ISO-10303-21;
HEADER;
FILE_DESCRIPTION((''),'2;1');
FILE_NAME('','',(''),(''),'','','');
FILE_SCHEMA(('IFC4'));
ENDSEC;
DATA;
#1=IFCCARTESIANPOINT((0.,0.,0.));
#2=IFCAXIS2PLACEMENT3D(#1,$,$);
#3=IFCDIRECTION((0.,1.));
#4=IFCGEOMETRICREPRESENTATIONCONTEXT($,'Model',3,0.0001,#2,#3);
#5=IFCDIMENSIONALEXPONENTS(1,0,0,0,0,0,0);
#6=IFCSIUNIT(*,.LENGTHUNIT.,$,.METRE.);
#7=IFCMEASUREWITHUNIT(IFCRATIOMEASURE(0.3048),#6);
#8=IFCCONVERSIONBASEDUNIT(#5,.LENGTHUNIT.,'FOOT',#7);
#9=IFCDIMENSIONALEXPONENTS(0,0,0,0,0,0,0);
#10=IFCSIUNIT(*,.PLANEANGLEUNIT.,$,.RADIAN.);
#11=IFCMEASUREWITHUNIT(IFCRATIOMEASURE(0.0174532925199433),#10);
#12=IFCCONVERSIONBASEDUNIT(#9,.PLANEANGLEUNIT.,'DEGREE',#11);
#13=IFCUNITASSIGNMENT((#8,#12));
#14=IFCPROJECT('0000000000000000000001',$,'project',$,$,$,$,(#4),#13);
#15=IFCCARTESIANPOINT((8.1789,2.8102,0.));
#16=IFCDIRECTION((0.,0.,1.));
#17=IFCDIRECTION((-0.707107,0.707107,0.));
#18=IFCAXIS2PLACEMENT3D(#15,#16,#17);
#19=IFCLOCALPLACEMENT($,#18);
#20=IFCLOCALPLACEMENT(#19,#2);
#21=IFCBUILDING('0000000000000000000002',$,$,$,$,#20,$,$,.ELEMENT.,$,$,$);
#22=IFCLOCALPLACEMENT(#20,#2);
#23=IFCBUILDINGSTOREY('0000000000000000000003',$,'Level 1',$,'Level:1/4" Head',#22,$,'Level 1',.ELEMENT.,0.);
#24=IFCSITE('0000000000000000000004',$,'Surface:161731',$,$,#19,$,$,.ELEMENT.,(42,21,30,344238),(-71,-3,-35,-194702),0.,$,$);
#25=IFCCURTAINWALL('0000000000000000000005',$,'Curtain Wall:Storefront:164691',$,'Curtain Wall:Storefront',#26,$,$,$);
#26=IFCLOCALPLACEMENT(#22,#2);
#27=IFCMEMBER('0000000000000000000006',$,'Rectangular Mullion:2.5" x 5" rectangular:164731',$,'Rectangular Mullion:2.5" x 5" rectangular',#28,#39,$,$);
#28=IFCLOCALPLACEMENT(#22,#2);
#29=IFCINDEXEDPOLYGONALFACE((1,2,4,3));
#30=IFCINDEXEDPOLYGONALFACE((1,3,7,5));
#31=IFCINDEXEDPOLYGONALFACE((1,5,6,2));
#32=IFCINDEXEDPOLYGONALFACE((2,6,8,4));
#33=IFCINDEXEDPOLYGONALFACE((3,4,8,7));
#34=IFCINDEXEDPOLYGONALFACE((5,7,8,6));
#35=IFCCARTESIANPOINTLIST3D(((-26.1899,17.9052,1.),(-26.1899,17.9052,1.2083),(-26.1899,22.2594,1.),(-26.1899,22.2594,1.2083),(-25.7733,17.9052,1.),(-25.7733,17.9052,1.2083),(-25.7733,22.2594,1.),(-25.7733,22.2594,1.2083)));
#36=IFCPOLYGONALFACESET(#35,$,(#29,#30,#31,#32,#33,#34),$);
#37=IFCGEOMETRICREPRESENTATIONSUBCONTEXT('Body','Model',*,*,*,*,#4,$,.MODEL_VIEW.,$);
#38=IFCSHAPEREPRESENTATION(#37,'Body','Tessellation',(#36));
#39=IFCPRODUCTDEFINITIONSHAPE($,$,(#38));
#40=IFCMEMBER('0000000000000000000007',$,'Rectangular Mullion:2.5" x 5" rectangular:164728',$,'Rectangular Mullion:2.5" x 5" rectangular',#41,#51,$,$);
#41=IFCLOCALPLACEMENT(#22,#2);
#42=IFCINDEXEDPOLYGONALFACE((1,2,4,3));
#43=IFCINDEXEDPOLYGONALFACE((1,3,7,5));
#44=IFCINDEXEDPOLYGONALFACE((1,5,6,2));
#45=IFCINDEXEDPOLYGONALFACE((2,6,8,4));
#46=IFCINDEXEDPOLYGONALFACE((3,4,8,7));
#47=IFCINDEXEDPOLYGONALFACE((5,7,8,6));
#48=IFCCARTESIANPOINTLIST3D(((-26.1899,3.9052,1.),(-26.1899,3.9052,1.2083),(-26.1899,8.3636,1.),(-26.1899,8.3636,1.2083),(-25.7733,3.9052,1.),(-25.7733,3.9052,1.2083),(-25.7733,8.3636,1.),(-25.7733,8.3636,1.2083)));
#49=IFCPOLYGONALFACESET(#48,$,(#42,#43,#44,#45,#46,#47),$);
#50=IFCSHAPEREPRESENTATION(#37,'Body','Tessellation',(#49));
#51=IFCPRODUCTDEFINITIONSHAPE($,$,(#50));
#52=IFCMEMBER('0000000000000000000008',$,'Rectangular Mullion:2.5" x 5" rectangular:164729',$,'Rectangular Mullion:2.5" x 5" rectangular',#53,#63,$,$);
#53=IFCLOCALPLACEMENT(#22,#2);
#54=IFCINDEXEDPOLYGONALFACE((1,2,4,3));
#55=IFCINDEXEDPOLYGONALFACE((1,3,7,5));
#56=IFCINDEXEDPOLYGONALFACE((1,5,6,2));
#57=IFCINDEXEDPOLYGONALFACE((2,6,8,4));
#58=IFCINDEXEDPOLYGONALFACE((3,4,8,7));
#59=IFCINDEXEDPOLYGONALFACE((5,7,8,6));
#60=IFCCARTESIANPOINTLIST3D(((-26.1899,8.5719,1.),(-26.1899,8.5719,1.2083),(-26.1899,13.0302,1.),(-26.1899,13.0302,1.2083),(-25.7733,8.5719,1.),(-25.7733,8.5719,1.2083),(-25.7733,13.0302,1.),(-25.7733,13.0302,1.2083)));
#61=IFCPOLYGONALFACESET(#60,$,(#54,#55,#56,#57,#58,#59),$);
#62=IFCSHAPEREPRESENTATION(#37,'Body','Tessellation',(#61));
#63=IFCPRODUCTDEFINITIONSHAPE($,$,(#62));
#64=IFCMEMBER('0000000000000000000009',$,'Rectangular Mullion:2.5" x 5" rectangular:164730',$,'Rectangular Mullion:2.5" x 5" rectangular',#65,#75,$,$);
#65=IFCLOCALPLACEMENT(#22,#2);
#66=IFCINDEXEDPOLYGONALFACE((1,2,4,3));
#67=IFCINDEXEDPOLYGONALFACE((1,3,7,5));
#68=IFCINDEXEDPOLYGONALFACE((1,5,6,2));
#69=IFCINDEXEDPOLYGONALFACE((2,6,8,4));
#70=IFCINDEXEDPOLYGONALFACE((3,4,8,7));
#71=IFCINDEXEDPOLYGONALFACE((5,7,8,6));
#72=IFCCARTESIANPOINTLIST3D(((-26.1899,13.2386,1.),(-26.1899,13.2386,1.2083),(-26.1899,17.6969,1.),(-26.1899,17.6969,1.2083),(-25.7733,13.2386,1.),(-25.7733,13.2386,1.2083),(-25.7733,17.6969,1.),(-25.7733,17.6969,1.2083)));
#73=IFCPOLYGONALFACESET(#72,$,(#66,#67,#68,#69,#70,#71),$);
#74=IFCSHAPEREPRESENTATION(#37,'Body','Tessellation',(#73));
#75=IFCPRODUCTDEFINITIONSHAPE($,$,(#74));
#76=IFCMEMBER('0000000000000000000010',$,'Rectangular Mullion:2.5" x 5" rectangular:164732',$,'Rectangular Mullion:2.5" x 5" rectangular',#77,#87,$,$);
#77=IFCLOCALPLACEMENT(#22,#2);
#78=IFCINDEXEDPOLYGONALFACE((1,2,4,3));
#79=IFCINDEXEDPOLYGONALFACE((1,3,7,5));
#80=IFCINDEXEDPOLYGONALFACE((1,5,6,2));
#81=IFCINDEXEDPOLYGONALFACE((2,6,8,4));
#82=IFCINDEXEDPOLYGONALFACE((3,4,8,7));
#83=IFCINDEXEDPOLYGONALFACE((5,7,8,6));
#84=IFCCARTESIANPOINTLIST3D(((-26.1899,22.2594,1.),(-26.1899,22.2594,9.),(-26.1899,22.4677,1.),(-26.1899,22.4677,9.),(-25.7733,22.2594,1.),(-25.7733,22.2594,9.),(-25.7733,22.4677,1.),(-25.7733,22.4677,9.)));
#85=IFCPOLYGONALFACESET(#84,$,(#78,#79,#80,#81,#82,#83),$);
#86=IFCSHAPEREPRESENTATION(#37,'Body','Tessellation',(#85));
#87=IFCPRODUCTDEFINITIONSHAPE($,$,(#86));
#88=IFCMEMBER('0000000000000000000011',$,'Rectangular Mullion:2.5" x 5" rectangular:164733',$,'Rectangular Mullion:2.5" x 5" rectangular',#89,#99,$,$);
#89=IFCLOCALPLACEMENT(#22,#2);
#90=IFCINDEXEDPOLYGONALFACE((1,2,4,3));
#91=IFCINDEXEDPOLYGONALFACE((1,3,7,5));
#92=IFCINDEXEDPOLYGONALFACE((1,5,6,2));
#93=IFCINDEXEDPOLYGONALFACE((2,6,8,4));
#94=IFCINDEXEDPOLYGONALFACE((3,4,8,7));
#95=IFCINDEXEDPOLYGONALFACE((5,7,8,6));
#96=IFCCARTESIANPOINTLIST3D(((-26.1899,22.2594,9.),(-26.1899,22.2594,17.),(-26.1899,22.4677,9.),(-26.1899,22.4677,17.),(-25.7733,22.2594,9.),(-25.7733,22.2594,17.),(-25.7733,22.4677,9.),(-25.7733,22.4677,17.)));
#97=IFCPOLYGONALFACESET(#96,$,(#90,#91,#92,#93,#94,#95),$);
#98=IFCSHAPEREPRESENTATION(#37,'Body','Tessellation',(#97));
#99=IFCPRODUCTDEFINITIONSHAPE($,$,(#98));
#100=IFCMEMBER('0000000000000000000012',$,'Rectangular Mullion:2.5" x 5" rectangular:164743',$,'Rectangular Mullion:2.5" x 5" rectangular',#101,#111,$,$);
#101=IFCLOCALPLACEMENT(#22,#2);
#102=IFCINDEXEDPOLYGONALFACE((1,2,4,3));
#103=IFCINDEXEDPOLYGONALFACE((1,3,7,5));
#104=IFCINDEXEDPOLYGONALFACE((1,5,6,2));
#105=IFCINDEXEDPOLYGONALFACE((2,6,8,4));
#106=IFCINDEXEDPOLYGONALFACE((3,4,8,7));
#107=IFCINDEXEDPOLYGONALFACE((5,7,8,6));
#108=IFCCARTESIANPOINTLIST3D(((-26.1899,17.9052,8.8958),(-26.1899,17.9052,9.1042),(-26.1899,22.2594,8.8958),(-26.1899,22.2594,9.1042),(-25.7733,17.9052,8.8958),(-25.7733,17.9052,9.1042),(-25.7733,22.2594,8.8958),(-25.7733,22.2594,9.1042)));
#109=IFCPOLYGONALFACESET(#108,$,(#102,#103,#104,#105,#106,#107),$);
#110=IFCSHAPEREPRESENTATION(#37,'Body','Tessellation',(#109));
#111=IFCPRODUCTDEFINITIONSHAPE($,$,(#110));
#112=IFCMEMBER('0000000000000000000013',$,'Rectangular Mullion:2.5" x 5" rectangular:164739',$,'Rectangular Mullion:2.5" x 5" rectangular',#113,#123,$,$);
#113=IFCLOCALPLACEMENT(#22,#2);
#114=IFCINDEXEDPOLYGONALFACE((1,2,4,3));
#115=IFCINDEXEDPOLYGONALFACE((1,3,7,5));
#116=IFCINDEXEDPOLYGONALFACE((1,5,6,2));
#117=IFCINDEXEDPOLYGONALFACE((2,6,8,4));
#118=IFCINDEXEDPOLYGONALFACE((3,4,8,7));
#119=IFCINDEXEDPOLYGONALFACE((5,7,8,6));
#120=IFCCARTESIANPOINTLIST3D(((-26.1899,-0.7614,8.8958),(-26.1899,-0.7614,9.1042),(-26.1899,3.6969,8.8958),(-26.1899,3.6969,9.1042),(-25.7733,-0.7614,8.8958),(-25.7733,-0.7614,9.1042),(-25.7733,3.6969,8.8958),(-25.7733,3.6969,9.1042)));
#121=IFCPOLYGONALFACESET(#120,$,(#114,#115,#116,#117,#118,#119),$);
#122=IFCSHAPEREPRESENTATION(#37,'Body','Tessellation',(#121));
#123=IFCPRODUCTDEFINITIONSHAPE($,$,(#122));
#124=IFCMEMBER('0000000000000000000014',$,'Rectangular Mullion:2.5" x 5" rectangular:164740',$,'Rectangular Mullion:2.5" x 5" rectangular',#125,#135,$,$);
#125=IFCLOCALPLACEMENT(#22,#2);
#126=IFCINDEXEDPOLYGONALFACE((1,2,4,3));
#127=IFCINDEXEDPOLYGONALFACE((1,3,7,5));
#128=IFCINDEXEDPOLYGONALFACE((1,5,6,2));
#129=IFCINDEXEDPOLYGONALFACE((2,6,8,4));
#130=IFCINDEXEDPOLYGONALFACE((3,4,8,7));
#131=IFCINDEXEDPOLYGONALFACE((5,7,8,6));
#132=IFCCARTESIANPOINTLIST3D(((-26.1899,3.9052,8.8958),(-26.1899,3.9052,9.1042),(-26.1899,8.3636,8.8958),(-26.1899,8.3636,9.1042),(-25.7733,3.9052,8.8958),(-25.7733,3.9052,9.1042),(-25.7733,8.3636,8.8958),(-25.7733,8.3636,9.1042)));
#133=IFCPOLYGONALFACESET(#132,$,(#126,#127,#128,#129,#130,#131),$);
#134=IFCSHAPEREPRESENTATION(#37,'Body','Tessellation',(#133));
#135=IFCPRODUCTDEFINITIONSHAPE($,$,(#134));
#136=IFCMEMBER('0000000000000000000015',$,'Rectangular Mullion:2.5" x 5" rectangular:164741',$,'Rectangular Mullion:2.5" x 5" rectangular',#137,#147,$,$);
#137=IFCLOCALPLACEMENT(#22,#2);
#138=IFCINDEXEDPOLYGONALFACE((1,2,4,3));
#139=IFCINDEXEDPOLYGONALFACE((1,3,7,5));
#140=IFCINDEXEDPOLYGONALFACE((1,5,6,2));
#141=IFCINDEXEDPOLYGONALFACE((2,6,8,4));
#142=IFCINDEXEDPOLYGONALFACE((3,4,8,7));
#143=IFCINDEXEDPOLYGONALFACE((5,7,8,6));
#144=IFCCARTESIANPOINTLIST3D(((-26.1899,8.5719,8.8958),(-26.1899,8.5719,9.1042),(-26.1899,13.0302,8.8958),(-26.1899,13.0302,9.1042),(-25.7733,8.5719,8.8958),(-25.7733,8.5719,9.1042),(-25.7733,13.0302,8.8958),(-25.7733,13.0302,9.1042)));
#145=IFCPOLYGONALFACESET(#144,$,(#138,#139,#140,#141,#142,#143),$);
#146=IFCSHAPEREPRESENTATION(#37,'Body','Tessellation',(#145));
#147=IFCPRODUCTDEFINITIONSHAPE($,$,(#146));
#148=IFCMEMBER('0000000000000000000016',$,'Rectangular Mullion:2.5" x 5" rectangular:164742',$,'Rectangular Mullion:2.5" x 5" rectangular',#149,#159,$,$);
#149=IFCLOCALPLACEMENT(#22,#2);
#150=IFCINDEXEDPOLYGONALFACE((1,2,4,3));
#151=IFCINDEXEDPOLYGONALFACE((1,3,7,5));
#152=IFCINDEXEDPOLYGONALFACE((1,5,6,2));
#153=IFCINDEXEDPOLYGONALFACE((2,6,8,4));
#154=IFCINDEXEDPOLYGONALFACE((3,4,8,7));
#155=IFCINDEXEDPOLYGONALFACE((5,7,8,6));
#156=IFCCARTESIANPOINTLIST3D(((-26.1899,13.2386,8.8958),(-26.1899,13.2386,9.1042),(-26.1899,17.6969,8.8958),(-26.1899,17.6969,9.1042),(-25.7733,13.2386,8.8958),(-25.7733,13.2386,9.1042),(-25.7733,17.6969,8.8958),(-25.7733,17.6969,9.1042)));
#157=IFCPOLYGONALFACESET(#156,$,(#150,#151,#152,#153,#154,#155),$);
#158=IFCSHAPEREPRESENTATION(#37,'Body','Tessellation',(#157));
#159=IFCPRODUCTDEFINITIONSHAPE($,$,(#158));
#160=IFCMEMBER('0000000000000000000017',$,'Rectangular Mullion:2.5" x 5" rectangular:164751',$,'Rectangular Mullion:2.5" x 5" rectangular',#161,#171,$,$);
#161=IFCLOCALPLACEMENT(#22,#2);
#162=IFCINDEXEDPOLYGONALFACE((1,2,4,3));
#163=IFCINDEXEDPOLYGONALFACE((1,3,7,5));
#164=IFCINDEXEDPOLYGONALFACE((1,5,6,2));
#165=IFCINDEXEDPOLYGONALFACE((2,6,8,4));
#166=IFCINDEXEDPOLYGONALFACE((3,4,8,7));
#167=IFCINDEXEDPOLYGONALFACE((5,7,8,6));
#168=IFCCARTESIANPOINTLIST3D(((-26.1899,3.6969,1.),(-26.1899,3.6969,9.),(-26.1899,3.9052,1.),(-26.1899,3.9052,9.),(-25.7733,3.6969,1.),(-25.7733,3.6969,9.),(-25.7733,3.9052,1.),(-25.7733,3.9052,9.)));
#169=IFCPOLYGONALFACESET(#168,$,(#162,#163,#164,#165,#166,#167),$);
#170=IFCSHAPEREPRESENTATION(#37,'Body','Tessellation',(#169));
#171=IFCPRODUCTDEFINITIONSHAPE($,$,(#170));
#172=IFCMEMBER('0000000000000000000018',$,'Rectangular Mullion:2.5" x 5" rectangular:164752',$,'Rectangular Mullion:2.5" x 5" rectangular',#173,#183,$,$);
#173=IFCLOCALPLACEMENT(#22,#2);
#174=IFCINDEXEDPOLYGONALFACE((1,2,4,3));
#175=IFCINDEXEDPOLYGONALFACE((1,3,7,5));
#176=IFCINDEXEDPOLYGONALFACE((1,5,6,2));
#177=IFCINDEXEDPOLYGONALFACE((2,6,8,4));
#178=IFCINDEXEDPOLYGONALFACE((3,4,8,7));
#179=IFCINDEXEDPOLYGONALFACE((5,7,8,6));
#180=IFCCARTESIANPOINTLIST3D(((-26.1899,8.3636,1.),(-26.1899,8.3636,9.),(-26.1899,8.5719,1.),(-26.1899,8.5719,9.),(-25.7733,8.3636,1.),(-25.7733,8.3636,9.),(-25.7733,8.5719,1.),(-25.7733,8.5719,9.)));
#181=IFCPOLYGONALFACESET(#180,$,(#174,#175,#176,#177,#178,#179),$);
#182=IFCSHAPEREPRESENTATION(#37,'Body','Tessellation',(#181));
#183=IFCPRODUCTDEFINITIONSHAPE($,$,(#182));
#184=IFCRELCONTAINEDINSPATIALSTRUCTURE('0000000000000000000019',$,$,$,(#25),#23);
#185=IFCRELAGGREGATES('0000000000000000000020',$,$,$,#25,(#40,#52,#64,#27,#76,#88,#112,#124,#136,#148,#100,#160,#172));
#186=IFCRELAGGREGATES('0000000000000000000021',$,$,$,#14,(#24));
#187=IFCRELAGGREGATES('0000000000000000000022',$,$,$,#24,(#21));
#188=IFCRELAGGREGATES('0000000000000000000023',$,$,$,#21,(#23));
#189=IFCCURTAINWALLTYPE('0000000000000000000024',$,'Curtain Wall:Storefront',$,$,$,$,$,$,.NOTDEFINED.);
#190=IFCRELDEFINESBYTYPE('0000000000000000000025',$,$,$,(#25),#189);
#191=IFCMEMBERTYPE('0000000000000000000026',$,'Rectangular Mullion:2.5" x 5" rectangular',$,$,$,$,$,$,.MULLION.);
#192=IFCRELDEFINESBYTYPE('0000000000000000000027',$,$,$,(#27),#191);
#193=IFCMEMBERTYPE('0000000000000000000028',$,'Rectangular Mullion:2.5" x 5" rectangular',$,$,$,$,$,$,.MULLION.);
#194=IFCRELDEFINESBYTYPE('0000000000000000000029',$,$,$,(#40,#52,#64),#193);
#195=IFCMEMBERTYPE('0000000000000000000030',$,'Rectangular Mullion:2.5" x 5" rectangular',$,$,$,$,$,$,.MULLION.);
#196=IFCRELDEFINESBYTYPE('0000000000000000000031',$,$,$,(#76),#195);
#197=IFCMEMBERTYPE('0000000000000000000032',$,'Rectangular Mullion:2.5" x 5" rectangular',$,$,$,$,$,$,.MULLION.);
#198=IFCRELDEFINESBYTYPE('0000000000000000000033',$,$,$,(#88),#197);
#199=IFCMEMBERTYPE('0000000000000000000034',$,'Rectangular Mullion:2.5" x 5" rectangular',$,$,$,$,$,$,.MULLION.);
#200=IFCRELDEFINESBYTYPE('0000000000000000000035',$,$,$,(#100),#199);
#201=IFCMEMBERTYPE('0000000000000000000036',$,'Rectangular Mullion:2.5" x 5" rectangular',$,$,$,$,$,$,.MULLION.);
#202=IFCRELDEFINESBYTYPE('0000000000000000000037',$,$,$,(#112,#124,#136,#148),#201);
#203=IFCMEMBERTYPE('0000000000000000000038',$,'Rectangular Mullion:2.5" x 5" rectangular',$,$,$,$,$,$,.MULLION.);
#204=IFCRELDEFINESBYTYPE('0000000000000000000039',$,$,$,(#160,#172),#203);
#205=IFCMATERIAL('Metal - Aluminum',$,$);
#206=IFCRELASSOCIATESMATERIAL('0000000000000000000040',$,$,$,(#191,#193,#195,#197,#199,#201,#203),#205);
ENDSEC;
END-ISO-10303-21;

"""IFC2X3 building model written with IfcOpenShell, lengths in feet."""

from ifc_helpers import new_model, entity, si_unit, converted_unit, direction, frame, origin, origin_2d_with_axis, place, context, subcontext, project, spatial, rectangle, extrude, source, transform, mapped, material, type_object, type_shapes, element, aggregate, save


model = new_model("IFC2X3")

# Units and contexts
model_context = context("Model", 3, precision=0.0001, world=origin(), true_north=direction((0.0, 1.0)))
body_context = subcontext(model_context, "Body", "Model", "MODEL_VIEW")
ifc_project = project(units=[converted_unit("LENGTHUNIT", "FOOT", entity("IfcRatioMeasure", 0.3048), si_unit("LENGTHUNIT", "METRE"), dimensions=[1, 0, 0, 0, 0, 0, 0]), converted_unit("PLANEANGLEUNIT", "DEGREE", entity("IfcRatioMeasure", 0.0174532925199433), si_unit("PLANEANGLEUNIT", "RADIAN"), dimensions=[0, 0, 0, 0, 0, 0, 0])], contexts=[model_context])

# Site, building, storey
site_placement = place(None, frame((8.1789, 2.8102, 0.0), z_axis=(0.0, 0.0, 1.0), x_axis=(-0.707107, 0.707107, 0.0)))
site = spatial("IfcSite", under=ifc_project, at=site_placement, Name="Surface:161731", CompositionType="ELEMENT", RefLatitude=(42, 21, 30, 344238), RefLongitude=(-71, -3, -35, -194702), RefElevation=0.0)
building_placement = place(site_placement, origin())
building = spatial("IfcBuilding", under=site, at=building_placement, CompositionType="ELEMENT")
storey_placement = place(building_placement, origin())
storey = spatial("IfcBuildingStorey", under=building, at=storey_placement, Name="Level 1", ObjectType="Level:1/4\" Head", LongName="Level 1", CompositionType="ELEMENT", Elevation=0.0)

# Curtain wall, members
curtain_wall_type = type_object("IfcCurtainWallType", Name="Curtain Wall:Storefront", PredefinedType="NOTDEFINED")
curtain_wall_placement = place(storey_placement, origin())
curtain_wall = element("IfcCurtainWall", 1, at=curtain_wall_placement, inside=storey, type_object=curtain_wall_type, Name="Curtain Wall:Storefront:164691", ObjectType="Curtain Wall:Storefront")
ifc_material_1 = material(Name="Metal - Aluminum")
member_type_1 = type_object("IfcMemberType", Name="Rectangular Mullion:2.5\" x 5\" rectangular", PredefinedType="MULLION", material=ifc_material_1)
shared_shape_1 = source(origin(), body_context, "Body", "SweptSolid", [
    extrude(rectangle(XDim=0.4167, YDim=0.2083, at=origin_2d_with_axis()), frame((-0.1042, 0.0, -4.3542), z_axis=(0.0, 0.0, 1.0), x_axis=(0.0, -1.0, 0.0)), (0.0, 0.0, 1.0), 4.3542),
])
type_shapes(member_type_1, [shared_shape_1])
member_1_placement = place(curtain_wall_placement, frame((-25.9816, 17.9052, 1.0), z_axis=(0.0, -1.0, 0.0), x_axis=(0.0, 0.0, -1.0)))
member_1 = element("IfcMember", 2, at=member_1_placement, type_object=member_type_1, Name="Rectangular Mullion:2.5\" x 5\" rectangular:164731", ObjectType="Rectangular Mullion:2.5\" x 5\" rectangular", context=body_context, shape_type="MappedRepresentation", body=[
    mapped(shared_shape_1, transform((0.0, 0.0, 0.0), scale=1.0)),
])
member_type_2 = type_object("IfcMemberType", Name="Rectangular Mullion:2.5\" x 5\" rectangular", PredefinedType="MULLION", material=ifc_material_1)
shared_shape_2 = source(origin(), body_context, "Body", "SweptSolid", [
    extrude(rectangle(XDim=0.4167, YDim=0.2083, at=origin_2d_with_axis()), frame((-0.1042, 0.0, -4.4583), z_axis=(0.0, 0.0, 1.0), x_axis=(0.0, -1.0, 0.0)), (0.0, 0.0, 1.0), 4.4583),
])
type_shapes(member_type_2, [shared_shape_2])
member_2_placement = place(curtain_wall_placement, frame((-25.9816, 3.9052, 1.0), z_axis=(0.0, -1.0, 0.0), x_axis=(0.0, 0.0, -1.0)))
member_2 = element("IfcMember", 3, at=member_2_placement, type_object=member_type_2, Name="Rectangular Mullion:2.5\" x 5\" rectangular:164728", ObjectType="Rectangular Mullion:2.5\" x 5\" rectangular", context=body_context, shape_type="MappedRepresentation", body=[
    mapped(shared_shape_2, transform((0.0, 0.0, 0.0), scale=1.0)),
])
member_3_placement = place(curtain_wall_placement, frame((-25.9816, 8.5719, 1.0), z_axis=(0.0, -1.0, 0.0), x_axis=(0.0, 0.0, -1.0)))
member_3 = element("IfcMember", 4, at=member_3_placement, type_object=member_type_2, Name="Rectangular Mullion:2.5\" x 5\" rectangular:164729", ObjectType="Rectangular Mullion:2.5\" x 5\" rectangular", context=body_context, shape_type="MappedRepresentation", body=[
    mapped(shared_shape_2, transform((0.0, 0.0, 0.0), scale=1.0)),
])
member_4_placement = place(curtain_wall_placement, frame((-25.9816, 13.2386, 1.0), z_axis=(0.0, -1.0, 0.0), x_axis=(0.0, 0.0, -1.0)))
member_4 = element("IfcMember", 5, at=member_4_placement, type_object=member_type_2, Name="Rectangular Mullion:2.5\" x 5\" rectangular:164730", ObjectType="Rectangular Mullion:2.5\" x 5\" rectangular", context=body_context, shape_type="MappedRepresentation", body=[
    mapped(shared_shape_2, transform((0.0, 0.0, 0.0), scale=1.0)),
])
member_type_3 = type_object("IfcMemberType", Name="Rectangular Mullion:2.5\" x 5\" rectangular", PredefinedType="MULLION", material=ifc_material_1)
shared_shape_3 = source(origin(), body_context, "Body", "SweptSolid", [
    extrude(rectangle(XDim=0.4167, YDim=0.2083, at=origin_2d_with_axis()), frame((-0.1042, 0.0, -8.0), z_axis=(0.0, 0.0, 1.0), x_axis=(0.0, -1.0, 0.0)), (0.0, 0.0, 1.0), 8.0),
])
type_shapes(member_type_3, [shared_shape_3])
member_5_placement = place(curtain_wall_placement, frame((-25.9816, 22.4677, 1.0), z_axis=(0.0, 0.0, -1.0), x_axis=(0.0, 1.0, 0.0)))
member_5 = element("IfcMember", 6, at=member_5_placement, type_object=member_type_3, Name="Rectangular Mullion:2.5\" x 5\" rectangular:164732", ObjectType="Rectangular Mullion:2.5\" x 5\" rectangular", context=body_context, shape_type="MappedRepresentation", body=[
    mapped(shared_shape_3, transform((0.0, 0.0, 0.0), scale=1.0)),
])
member_type_4 = type_object("IfcMemberType", Name="Rectangular Mullion:2.5\" x 5\" rectangular", PredefinedType="MULLION", material=ifc_material_1)
shared_shape_4 = source(origin(), body_context, "Body", "SweptSolid", [
    extrude(rectangle(XDim=0.4167, YDim=0.2083, at=origin_2d_with_axis()), frame((-0.1042, 0.0, -8.0), z_axis=(0.0, 0.0, 1.0), x_axis=(0.0, -1.0, 0.0)), (0.0, 0.0, 1.0), 8.0),
])
type_shapes(member_type_4, [shared_shape_4])
member_6_placement = place(curtain_wall_placement, frame((-25.9816, 22.4677, 9.0), z_axis=(0.0, 0.0, -1.0), x_axis=(0.0, 1.0, 0.0)))
member_6 = element("IfcMember", 7, at=member_6_placement, type_object=member_type_4, Name="Rectangular Mullion:2.5\" x 5\" rectangular:164733", ObjectType="Rectangular Mullion:2.5\" x 5\" rectangular", context=body_context, shape_type="MappedRepresentation", body=[
    mapped(shared_shape_4, transform((0.0, 0.0, 0.0), scale=1.0)),
])
member_type_5 = type_object("IfcMemberType", Name="Rectangular Mullion:2.5\" x 5\" rectangular", PredefinedType="MULLION", material=ifc_material_1)
shared_shape_5 = source(origin(), body_context, "Body", "SweptSolid", [
    extrude(rectangle(XDim=0.4167, YDim=0.2083, at=origin_2d_with_axis()), frame((0.0, 0.0, -4.3542), z_axis=(0.0, 0.0, 1.0), x_axis=(0.0, -1.0, 0.0)), (0.0, 0.0, 1.0), 4.3542),
])
type_shapes(member_type_5, [shared_shape_5])
member_7_placement = place(curtain_wall_placement, frame((-25.9816, 22.2594, 9.0), z_axis=(0.0, 1.0, 0.0), x_axis=(0.0, 0.0, 1.0)))
member_7 = element("IfcMember", 8, at=member_7_placement, type_object=member_type_5, Name="Rectangular Mullion:2.5\" x 5\" rectangular:164743", ObjectType="Rectangular Mullion:2.5\" x 5\" rectangular", context=body_context, shape_type="MappedRepresentation", body=[
    mapped(shared_shape_5, transform((0.0, 0.0, 0.0), scale=1.0)),
])
member_type_6 = type_object("IfcMemberType", Name="Rectangular Mullion:2.5\" x 5\" rectangular", PredefinedType="MULLION", material=ifc_material_1)
shared_shape_6 = source(origin(), body_context, "Body", "SweptSolid", [
    extrude(rectangle(XDim=0.4167, YDim=0.2083, at=origin_2d_with_axis()), frame((0.0, 0.0, -4.4583), z_axis=(0.0, 0.0, 1.0), x_axis=(0.0, -1.0, 0.0)), (0.0, 0.0, 1.0), 4.4583),
])
type_shapes(member_type_6, [shared_shape_6])
member_8_placement = place(curtain_wall_placement, frame((-25.9816, 3.6969, 9.0), z_axis=(0.0, 1.0, 0.0), x_axis=(0.0, 0.0, 1.0)))
member_8 = element("IfcMember", 9, at=member_8_placement, type_object=member_type_6, Name="Rectangular Mullion:2.5\" x 5\" rectangular:164739", ObjectType="Rectangular Mullion:2.5\" x 5\" rectangular", context=body_context, shape_type="MappedRepresentation", body=[
    mapped(shared_shape_6, transform((0.0, 0.0, 0.0), scale=1.0)),
])
member_9_placement = place(curtain_wall_placement, frame((-25.9816, 8.3636, 9.0), z_axis=(0.0, 1.0, 0.0), x_axis=(0.0, 0.0, 1.0)))
member_9 = element("IfcMember", 10, at=member_9_placement, type_object=member_type_6, Name="Rectangular Mullion:2.5\" x 5\" rectangular:164740", ObjectType="Rectangular Mullion:2.5\" x 5\" rectangular", context=body_context, shape_type="MappedRepresentation", body=[
    mapped(shared_shape_6, transform((0.0, 0.0, 0.0), scale=1.0)),
])
member_10_placement = place(curtain_wall_placement, frame((-25.9816, 13.0302, 9.0), z_axis=(0.0, 1.0, 0.0), x_axis=(0.0, 0.0, 1.0)))
member_10 = element("IfcMember", 11, at=member_10_placement, type_object=member_type_6, Name="Rectangular Mullion:2.5\" x 5\" rectangular:164741", ObjectType="Rectangular Mullion:2.5\" x 5\" rectangular", context=body_context, shape_type="MappedRepresentation", body=[
    mapped(shared_shape_6, transform((0.0, 0.0, 0.0), scale=1.0)),
])
member_11_placement = place(curtain_wall_placement, frame((-25.9816, 17.6969, 9.0), z_axis=(0.0, 1.0, 0.0), x_axis=(0.0, 0.0, 1.0)))
member_11 = element("IfcMember", 12, at=member_11_placement, type_object=member_type_6, Name="Rectangular Mullion:2.5\" x 5\" rectangular:164742", ObjectType="Rectangular Mullion:2.5\" x 5\" rectangular", context=body_context, shape_type="MappedRepresentation", body=[
    mapped(shared_shape_6, transform((0.0, 0.0, 0.0), scale=1.0)),
])
member_type_7 = type_object("IfcMemberType", Name="Rectangular Mullion:2.5\" x 5\" rectangular", PredefinedType="MULLION", material=ifc_material_1)
shared_shape_7 = source(origin(), body_context, "Body", "SweptSolid", [
    extrude(rectangle(XDim=0.4167, YDim=0.2083, at=origin_2d_with_axis()), frame((0.0, 0.0, -8.0), z_axis=(0.0, 0.0, 1.0), x_axis=(0.0, -1.0, 0.0)), (0.0, 0.0, 1.0), 8.0),
])
type_shapes(member_type_7, [shared_shape_7])
member_12_placement = place(curtain_wall_placement, frame((-25.9816, 3.8011, 1.0), z_axis=(0.0, 0.0, -1.0), x_axis=(0.0, 1.0, 0.0)))
member_12 = element("IfcMember", 13, at=member_12_placement, type_object=member_type_7, Name="Rectangular Mullion:2.5\" x 5\" rectangular:164751", ObjectType="Rectangular Mullion:2.5\" x 5\" rectangular", context=body_context, shape_type="MappedRepresentation", body=[
    mapped(shared_shape_7, transform((0.0, 0.0, 0.0), scale=1.0)),
])
member_13_placement = place(curtain_wall_placement, frame((-25.9816, 8.4677, 1.0), z_axis=(0.0, 0.0, -1.0), x_axis=(0.0, 1.0, 0.0)))
member_13 = element("IfcMember", 14, at=member_13_placement, type_object=member_type_7, Name="Rectangular Mullion:2.5\" x 5\" rectangular:164752", ObjectType="Rectangular Mullion:2.5\" x 5\" rectangular", context=body_context, shape_type="MappedRepresentation", body=[
    mapped(shared_shape_7, transform((0.0, 0.0, 0.0), scale=1.0)),
])
aggregate(curtain_wall, [member_2, member_3, member_4, member_1, member_5, member_6, member_8, member_9, member_10, member_11, member_7, member_12, member_13])

save(model, "model.ifc")
